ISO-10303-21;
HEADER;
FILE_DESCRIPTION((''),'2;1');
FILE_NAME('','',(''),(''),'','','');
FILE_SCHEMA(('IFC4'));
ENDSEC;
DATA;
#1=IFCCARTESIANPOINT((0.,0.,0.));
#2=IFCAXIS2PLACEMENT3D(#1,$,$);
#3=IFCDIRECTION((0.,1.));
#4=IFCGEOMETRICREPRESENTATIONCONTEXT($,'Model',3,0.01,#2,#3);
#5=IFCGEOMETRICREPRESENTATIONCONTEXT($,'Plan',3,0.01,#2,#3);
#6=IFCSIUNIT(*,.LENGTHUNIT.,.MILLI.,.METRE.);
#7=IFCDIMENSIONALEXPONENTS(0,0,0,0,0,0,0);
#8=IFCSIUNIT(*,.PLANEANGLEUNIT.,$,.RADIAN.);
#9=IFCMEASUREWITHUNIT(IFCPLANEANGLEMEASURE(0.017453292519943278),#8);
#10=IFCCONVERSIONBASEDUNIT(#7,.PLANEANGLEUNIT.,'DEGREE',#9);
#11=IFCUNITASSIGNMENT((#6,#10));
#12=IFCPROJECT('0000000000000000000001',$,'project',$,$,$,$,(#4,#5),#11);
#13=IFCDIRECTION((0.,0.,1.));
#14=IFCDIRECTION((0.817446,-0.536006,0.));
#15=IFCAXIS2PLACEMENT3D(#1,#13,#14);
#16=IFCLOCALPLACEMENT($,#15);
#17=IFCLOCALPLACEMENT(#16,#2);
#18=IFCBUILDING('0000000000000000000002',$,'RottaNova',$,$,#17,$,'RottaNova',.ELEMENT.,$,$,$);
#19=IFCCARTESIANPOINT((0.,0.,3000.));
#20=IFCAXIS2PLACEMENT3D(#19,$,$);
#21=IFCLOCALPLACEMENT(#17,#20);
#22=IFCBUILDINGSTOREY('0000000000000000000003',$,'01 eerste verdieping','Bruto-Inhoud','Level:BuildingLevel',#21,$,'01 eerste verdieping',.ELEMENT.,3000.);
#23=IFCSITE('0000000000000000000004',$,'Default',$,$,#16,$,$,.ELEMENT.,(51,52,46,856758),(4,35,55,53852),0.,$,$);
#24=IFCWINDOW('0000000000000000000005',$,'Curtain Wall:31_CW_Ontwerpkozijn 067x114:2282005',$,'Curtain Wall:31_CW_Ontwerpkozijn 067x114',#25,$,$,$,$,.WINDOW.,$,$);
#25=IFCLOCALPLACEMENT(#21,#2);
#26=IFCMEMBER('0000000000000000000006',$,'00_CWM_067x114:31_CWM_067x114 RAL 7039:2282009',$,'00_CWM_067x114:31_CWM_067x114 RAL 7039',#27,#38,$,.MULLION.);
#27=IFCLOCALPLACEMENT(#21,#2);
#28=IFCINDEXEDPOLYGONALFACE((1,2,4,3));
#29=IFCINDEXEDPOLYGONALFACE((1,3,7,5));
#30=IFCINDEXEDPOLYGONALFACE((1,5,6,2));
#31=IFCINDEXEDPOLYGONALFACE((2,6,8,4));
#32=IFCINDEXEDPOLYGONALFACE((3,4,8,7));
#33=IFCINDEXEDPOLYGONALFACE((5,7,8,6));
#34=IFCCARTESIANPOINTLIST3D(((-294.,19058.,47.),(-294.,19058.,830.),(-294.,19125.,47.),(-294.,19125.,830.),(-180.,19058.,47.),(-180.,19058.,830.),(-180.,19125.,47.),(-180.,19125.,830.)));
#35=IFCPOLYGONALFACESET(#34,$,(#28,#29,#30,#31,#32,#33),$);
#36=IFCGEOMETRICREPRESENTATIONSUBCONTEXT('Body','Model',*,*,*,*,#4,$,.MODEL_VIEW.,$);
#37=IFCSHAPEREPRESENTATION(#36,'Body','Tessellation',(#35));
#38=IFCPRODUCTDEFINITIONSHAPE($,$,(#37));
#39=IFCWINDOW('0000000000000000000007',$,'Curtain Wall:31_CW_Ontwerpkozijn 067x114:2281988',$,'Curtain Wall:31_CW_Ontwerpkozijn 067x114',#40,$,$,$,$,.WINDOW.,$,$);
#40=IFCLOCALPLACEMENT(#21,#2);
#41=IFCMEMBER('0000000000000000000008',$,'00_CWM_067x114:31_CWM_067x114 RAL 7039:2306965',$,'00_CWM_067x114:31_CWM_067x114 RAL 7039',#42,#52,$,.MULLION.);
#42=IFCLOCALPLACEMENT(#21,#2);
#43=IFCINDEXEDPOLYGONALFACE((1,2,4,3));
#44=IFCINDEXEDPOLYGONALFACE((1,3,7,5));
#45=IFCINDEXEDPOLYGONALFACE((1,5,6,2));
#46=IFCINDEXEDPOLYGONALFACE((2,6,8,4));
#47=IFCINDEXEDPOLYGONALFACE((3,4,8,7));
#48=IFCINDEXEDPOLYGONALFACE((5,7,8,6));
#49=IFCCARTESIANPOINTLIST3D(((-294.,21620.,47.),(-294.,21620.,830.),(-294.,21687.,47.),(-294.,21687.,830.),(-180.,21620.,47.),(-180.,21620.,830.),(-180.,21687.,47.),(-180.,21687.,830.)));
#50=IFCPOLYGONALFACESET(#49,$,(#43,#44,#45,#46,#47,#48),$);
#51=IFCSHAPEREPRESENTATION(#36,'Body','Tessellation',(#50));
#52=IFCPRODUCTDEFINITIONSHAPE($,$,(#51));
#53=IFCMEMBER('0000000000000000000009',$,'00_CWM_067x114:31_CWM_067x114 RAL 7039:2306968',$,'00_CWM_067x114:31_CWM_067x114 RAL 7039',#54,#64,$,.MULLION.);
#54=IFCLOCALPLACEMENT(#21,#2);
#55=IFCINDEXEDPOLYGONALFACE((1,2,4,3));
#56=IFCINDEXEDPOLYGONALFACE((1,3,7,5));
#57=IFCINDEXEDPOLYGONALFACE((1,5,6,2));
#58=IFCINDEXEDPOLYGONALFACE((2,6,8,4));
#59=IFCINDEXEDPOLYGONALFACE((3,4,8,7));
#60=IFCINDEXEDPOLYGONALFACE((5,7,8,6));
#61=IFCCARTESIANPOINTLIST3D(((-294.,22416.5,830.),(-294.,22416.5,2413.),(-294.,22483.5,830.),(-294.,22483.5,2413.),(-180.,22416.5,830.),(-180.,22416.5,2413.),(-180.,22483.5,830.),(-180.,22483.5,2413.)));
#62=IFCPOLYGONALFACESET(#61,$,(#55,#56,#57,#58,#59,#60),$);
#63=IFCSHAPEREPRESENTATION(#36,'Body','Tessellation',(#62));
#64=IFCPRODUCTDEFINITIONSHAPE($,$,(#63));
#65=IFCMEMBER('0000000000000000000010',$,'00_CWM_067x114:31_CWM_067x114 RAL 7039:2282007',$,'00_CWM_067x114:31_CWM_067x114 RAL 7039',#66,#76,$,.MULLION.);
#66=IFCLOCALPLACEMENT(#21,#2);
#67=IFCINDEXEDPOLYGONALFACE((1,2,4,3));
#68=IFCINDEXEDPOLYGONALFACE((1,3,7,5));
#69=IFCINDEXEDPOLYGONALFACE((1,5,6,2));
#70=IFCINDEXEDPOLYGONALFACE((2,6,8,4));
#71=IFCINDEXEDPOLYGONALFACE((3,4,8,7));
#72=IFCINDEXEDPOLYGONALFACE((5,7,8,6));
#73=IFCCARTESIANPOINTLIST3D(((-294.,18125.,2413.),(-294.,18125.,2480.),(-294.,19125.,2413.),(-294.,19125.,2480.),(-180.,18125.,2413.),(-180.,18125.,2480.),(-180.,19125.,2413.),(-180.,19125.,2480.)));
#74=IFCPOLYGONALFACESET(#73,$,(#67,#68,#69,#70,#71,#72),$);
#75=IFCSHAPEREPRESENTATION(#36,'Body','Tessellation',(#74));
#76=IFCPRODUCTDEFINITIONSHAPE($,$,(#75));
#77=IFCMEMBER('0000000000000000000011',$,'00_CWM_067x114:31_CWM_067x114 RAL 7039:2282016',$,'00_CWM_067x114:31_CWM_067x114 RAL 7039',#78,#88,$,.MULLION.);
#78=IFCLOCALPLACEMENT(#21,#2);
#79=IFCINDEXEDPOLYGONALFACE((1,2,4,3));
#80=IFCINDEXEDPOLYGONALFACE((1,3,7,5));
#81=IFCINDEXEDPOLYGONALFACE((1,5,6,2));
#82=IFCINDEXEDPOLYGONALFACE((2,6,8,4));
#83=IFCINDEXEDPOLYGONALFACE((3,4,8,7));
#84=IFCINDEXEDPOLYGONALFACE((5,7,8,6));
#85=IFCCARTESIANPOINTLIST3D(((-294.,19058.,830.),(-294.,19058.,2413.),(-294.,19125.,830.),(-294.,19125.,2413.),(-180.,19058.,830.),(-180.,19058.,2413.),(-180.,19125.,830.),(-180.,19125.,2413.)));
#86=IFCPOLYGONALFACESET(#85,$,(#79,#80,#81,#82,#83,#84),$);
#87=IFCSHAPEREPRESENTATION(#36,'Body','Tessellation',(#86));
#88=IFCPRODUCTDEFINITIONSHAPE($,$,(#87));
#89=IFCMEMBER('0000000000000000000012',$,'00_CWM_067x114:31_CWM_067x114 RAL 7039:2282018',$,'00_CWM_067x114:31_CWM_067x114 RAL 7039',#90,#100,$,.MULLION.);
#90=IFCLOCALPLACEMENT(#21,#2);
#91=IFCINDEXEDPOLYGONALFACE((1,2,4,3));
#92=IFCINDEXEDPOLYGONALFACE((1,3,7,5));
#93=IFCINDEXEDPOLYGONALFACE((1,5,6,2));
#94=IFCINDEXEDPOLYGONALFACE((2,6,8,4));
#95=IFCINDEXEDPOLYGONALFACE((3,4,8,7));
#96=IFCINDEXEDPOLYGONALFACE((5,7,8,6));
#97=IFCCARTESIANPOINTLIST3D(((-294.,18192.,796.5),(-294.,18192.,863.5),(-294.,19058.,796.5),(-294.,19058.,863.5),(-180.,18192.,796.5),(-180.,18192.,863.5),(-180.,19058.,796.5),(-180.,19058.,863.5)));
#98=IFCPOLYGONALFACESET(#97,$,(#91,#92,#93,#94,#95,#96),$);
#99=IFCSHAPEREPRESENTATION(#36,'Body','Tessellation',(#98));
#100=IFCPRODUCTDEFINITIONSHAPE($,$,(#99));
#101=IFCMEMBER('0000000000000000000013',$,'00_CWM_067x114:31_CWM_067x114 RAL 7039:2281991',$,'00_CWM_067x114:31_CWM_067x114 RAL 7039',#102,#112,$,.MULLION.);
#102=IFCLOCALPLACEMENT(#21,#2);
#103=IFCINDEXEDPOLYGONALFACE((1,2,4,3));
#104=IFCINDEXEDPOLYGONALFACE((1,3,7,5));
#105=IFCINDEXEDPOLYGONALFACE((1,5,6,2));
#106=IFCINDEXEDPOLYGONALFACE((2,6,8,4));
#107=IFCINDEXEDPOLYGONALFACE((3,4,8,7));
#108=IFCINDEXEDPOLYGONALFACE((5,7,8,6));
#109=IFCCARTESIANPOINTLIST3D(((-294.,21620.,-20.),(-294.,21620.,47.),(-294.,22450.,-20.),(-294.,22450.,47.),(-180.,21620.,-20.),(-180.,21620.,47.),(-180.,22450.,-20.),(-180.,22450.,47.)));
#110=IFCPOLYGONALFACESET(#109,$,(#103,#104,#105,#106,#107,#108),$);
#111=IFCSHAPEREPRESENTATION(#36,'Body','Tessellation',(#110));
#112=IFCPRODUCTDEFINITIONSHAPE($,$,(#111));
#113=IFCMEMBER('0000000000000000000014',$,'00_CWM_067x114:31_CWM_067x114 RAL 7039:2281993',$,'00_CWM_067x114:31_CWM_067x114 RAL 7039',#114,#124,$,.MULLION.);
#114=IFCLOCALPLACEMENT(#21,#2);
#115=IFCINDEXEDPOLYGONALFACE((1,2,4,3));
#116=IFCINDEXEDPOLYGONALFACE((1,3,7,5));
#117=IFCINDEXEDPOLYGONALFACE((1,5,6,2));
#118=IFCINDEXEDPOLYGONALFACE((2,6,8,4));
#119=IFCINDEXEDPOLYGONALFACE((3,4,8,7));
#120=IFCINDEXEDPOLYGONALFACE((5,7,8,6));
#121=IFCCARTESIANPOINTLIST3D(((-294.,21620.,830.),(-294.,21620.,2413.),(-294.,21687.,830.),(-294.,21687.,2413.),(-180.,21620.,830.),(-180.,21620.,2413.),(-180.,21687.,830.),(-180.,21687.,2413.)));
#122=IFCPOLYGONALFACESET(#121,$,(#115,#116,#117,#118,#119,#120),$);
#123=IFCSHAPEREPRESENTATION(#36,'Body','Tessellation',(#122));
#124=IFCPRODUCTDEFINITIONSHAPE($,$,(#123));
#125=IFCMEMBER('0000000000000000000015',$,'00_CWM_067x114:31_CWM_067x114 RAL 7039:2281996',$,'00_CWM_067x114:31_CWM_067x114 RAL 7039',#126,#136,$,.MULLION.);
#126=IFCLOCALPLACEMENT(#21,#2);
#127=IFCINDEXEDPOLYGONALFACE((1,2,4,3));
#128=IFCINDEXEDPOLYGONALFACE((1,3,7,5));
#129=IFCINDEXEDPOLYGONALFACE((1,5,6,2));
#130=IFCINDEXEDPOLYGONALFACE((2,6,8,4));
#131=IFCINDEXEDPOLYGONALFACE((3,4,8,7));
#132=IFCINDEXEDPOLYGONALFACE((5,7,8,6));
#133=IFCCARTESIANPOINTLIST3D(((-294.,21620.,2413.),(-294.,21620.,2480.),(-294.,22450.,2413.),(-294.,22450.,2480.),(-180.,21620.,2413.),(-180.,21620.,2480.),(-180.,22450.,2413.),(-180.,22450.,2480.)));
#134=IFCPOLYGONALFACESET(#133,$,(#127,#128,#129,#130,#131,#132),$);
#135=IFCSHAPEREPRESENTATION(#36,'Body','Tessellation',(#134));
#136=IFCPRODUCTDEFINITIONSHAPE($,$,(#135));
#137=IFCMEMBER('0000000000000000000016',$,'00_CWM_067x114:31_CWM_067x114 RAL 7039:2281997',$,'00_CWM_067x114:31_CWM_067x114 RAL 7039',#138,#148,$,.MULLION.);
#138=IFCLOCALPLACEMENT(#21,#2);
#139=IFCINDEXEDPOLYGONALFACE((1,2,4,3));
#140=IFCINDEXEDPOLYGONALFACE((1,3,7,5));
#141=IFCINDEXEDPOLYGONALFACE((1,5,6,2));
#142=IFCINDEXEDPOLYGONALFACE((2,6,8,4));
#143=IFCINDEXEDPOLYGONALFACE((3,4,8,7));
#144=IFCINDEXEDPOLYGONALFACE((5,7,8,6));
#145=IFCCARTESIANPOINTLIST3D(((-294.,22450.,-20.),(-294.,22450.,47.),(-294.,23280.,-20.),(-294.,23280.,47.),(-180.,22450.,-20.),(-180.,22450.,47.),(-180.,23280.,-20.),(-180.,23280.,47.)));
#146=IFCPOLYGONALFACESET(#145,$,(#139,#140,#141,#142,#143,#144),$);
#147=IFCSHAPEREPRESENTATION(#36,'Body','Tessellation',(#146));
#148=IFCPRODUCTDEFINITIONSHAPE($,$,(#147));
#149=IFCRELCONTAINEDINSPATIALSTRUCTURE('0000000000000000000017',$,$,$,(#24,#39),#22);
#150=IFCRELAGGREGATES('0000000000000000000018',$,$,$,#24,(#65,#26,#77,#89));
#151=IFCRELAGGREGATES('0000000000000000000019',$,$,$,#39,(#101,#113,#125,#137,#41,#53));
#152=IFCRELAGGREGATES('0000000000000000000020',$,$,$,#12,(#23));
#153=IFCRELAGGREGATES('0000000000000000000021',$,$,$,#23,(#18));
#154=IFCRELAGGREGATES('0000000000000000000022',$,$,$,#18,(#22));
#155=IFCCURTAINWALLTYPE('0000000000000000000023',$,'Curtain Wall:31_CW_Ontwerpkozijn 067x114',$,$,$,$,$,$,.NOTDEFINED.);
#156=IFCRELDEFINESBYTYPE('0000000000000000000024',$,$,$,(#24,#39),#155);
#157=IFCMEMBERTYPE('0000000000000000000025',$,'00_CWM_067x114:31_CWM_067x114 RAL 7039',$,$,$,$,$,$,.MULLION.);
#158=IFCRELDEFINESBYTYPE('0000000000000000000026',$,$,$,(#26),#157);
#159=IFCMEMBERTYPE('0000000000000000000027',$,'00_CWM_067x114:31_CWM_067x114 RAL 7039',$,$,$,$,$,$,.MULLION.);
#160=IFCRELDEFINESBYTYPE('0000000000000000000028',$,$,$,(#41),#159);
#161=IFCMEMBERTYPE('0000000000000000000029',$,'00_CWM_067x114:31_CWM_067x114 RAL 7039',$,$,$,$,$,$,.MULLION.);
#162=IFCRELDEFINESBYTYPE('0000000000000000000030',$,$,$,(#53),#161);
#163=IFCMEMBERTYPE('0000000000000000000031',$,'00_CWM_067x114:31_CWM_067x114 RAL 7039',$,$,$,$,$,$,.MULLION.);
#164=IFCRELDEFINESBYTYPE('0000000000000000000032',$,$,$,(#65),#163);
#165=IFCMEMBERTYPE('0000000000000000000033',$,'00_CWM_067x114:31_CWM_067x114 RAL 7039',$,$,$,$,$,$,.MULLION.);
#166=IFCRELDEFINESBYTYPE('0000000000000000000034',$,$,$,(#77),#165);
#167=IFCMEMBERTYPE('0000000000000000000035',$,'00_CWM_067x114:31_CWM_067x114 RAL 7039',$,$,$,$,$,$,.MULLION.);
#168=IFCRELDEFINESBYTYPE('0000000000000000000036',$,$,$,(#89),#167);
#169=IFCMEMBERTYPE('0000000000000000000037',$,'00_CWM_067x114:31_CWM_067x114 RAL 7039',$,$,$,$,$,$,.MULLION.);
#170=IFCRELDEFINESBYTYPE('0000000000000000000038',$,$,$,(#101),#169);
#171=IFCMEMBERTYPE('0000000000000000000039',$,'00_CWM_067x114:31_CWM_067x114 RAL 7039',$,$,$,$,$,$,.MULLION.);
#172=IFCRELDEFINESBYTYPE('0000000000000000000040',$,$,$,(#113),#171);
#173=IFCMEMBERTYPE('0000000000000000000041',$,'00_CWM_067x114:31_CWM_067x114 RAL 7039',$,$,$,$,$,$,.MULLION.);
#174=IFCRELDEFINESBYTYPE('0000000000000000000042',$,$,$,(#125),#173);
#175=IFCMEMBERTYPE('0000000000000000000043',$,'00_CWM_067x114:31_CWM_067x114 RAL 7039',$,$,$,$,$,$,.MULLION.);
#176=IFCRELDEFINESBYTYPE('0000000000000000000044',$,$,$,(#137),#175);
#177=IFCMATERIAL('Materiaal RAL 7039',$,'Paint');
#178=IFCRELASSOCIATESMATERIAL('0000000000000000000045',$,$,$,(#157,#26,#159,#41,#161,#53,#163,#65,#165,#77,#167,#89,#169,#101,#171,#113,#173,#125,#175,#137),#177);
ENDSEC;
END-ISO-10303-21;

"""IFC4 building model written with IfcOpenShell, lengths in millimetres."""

from ifc_helpers import new_model, entity, si_unit, converted_unit, direction, frame, origin, place, context, subcontext, project, spatial, indexed_curve, outline, extrude, source, transform, mapped, material, type_object, type_shapes, element, aggregate, save


model = new_model("IFC4")

# Units and contexts
model_context = context("Model", 3, precision=0.01, world=origin(), true_north=direction((0.0, 1.0)))
plan_context = context("Plan", 3, precision=0.01, world=origin(), true_north=direction((0.0, 1.0)))
body_context = subcontext(model_context, "Body", "Model", "MODEL_VIEW")
ifc_project = project(units=[si_unit("LENGTHUNIT", "METRE", prefix="MILLI"), converted_unit("PLANEANGLEUNIT", "DEGREE", entity("IfcPlaneAngleMeasure", 0.017453292519943278), si_unit("PLANEANGLEUNIT", "RADIAN"), dimensions=[0, 0, 0, 0, 0, 0, 0])], contexts=[model_context, plan_context])

# Site, building, storey
site_placement = place(None, frame((0.0, 0.0, 0.0), z_axis=(0.0, 0.0, 1.0), x_axis=(0.817446, -0.536006, 0.0)))
site = spatial("IfcSite", under=ifc_project, at=site_placement, Name="Default", CompositionType="ELEMENT", RefLatitude=(51, 52, 46, 856758), RefLongitude=(4, 35, 55, 53852), RefElevation=0.0)
building_placement = place(site_placement, origin())
building = spatial("IfcBuilding", under=site, at=building_placement, Name="RottaNova", LongName="RottaNova", CompositionType="ELEMENT")
storey_placement = place(building_placement, frame((0.0, 0.0, 3000.0)))
storey = spatial("IfcBuildingStorey", under=building, at=storey_placement, Name="01 eerste verdieping", Description="Bruto-Inhoud", ObjectType="Level:BuildingLevel", LongName="01 eerste verdieping", CompositionType="ELEMENT", Elevation=3000.0)

# Window, member
curtain_wall_type = type_object("IfcCurtainWallType", Name="Curtain Wall:31_CW_Ontwerpkozijn 067x114", PredefinedType="NOTDEFINED")
window_1_placement = place(storey_placement, frame((0.0, 0.0, -3000.0)))
window_1 = element("IfcWindow", 1, at=window_1_placement, inside=storey, type_object=curtain_wall_type, Name="Curtain Wall:31_CW_Ontwerpkozijn 067x114:2282005", ObjectType="Curtain Wall:31_CW_Ontwerpkozijn 067x114", PredefinedType="WINDOW")
ifc_material_1 = material(Name="Materiaal RAL 7039", Category="Paint")
member_type_1 = type_object("IfcMemberType", Name="00_CWM_067x114:31_CWM_067x114 RAL 7039", PredefinedType="MULLION", material=ifc_material_1)
shared_shape_1 = source(origin(), body_context, "Body", "SweptSolid", [
    extrude(outline(indexed_curve([(-33.5, -57.0), (33.5, -57.0), (33.5, 57.0), (-33.5, 57.0), (-33.5, -57.0)], self_intersect=False)), frame((-33.5, -57.0, -783.0), z_axis=(0.0, 0.0, 1.0), x_axis=(-1.0, 0.0, 0.0)), (0.0, 0.0, 1.0), 783.0),
])
type_shapes(member_type_1, [shared_shape_1])
member_1_placement = place(window_1_placement, frame((-180.0, 19125.0, 3047.0), z_axis=(0.0, 0.0, -1.0), x_axis=(0.0, 1.0, 0.0)))
member_1 = element("IfcMember", 2, at=member_1_placement, type_object=member_type_1, material=ifc_material_1, Name="00_CWM_067x114:31_CWM_067x114 RAL 7039:2282009", ObjectType="00_CWM_067x114:31_CWM_067x114 RAL 7039", PredefinedType="MULLION", context=body_context, shape_type="MappedRepresentation", body=[
    mapped(shared_shape_1, transform((0.0, 0.0, 0.0), scale=1.0)),
])

# Window, members
window_2_placement = place(storey_placement, frame((0.0, 0.0, -3000.0)))
window_2 = element("IfcWindow", 3, at=window_2_placement, inside=storey, type_object=curtain_wall_type, Name="Curtain Wall:31_CW_Ontwerpkozijn 067x114:2281988", ObjectType="Curtain Wall:31_CW_Ontwerpkozijn 067x114", PredefinedType="WINDOW")
member_type_2 = type_object("IfcMemberType", Name="00_CWM_067x114:31_CWM_067x114 RAL 7039", PredefinedType="MULLION", material=ifc_material_1)
shared_shape_2 = source(origin(), body_context, "Body", "SweptSolid", [
    extrude(outline(indexed_curve([(-33.5, -57.0), (33.5, -57.0), (33.5, 57.0), (-33.5, 57.0), (-33.5, -57.0)], self_intersect=False)), frame((-33.5, -57.0, -783.0), z_axis=(0.0, 0.0, 1.0), x_axis=(-1.0, 0.0, 0.0)), (0.0, 0.0, 1.0), 783.0),
])
type_shapes(member_type_2, [shared_shape_2])
member_2_placement = place(window_2_placement, frame((-180.0, 21620.0, 3830.0), z_axis=(0.0, 0.0, 1.0), x_axis=(0.0, -1.0, 0.0)))
member_2 = element("IfcMember", 4, at=member_2_placement, type_object=member_type_2, material=ifc_material_1, Name="00_CWM_067x114:31_CWM_067x114 RAL 7039:2306965", ObjectType="00_CWM_067x114:31_CWM_067x114 RAL 7039", PredefinedType="MULLION", context=body_context, shape_type="MappedRepresentation", body=[
    mapped(shared_shape_2, transform((0.0, 0.0, 0.0), scale=1.0)),
])
member_type_3 = type_object("IfcMemberType", Name="00_CWM_067x114:31_CWM_067x114 RAL 7039", PredefinedType="MULLION", material=ifc_material_1)
shared_shape_3 = source(origin(), body_context, "Body", "SweptSolid", [
    extrude(outline(indexed_curve([(-33.5, -57.0), (33.5, -57.0), (33.5, 57.0), (-33.5, 57.0), (-33.5, -57.0)], self_intersect=False)), frame((0.0, -57.0, -1583.0), z_axis=(0.0, 0.0, 1.0), x_axis=(-1.0, 0.0, 0.0)), (0.0, 0.0, 1.0), 1583.0),
])
type_shapes(member_type_3, [shared_shape_3])
member_3_placement = place(window_2_placement, frame((-180.0, 22450.0, 3830.0), z_axis=(0.0, 0.0, -1.0), x_axis=(0.0, 1.0, 0.0)))
member_3 = element("IfcMember", 5, at=member_3_placement, type_object=member_type_3, material=ifc_material_1, Name="00_CWM_067x114:31_CWM_067x114 RAL 7039:2306968", ObjectType="00_CWM_067x114:31_CWM_067x114 RAL 7039", PredefinedType="MULLION", context=body_context, shape_type="MappedRepresentation", body=[
    mapped(shared_shape_3, transform((0.0, 0.0, 0.0), scale=1.0)),
])

# Members
member_type_4 = type_object("IfcMemberType", Name="00_CWM_067x114:31_CWM_067x114 RAL 7039", PredefinedType="MULLION", material=ifc_material_1)
shared_shape_4 = source(origin(), body_context, "Body", "SweptSolid", [
    extrude(outline(indexed_curve([(-33.5, -57.0), (33.5, -57.0), (33.5, 57.0), (-33.5, 57.0), (-33.5, -57.0)], self_intersect=False)), frame((-33.5, -57.0, -1000.0), z_axis=(0.0, 0.0, 1.0), x_axis=(-1.0, 0.0, 0.0)), (0.0, 0.0, 1.0), 1000.0),
])
type_shapes(member_type_4, [shared_shape_4])
member_4_placement = place(window_1_placement, frame((-180.0, 19125.0, 5480.0), z_axis=(0.0, 1.0, 0.0), x_axis=(0.0, 0.0, 1.0)))
member_4 = element("IfcMember", 6, at=member_4_placement, type_object=member_type_4, material=ifc_material_1, Name="00_CWM_067x114:31_CWM_067x114 RAL 7039:2282007", ObjectType="00_CWM_067x114:31_CWM_067x114 RAL 7039", PredefinedType="MULLION", context=body_context, shape_type="MappedRepresentation", body=[
    mapped(shared_shape_4, transform((0.0, 0.0, 0.0), scale=1.0)),
])
member_type_5 = type_object("IfcMemberType", Name="00_CWM_067x114:31_CWM_067x114 RAL 7039", PredefinedType="MULLION", material=ifc_material_1)
shared_shape_5 = source(origin(), body_context, "Body", "SweptSolid", [
    extrude(outline(indexed_curve([(-33.5, -57.0), (33.5, -57.0), (33.5, 57.0), (-33.5, 57.0), (-33.5, -57.0)], self_intersect=False)), frame((-33.5, -57.0, -1583.0), z_axis=(0.0, 0.0, 1.0), x_axis=(-1.0, 0.0, 0.0)), (0.0, 0.0, 1.0), 1583.0),
])
type_shapes(member_type_5, [shared_shape_5])
member_5_placement = place(window_1_placement, frame((-180.0, 19125.0, 3830.0), z_axis=(0.0, 0.0, -1.0), x_axis=(0.0, 1.0, 0.0)))
member_5 = element("IfcMember", 7, at=member_5_placement, type_object=member_type_5, material=ifc_material_1, Name="00_CWM_067x114:31_CWM_067x114 RAL 7039:2282016", ObjectType="00_CWM_067x114:31_CWM_067x114 RAL 7039", PredefinedType="MULLION", context=body_context, shape_type="MappedRepresentation", body=[
    mapped(shared_shape_5, transform((0.0, 0.0, 0.0), scale=1.0)),
])
member_type_6 = type_object("IfcMemberType", Name="00_CWM_067x114:31_CWM_067x114 RAL 7039", PredefinedType="MULLION", material=ifc_material_1)
shared_shape_6 = source(origin(), body_context, "Body", "SweptSolid", [
    extrude(outline(indexed_curve([(-33.5, -57.0), (33.5, -57.0), (33.5, 57.0), (-33.5, 57.0), (-33.5, -57.0)], self_intersect=False)), frame((0.0, -57.0, -866.0), z_axis=(0.0, 0.0, 1.0), x_axis=(-1.0, 0.0, 0.0)), (0.0, 0.0, 1.0), 866.0),
])
type_shapes(member_type_6, [shared_shape_6])
member_6_placement = place(window_1_placement, frame((-180.0, 19058.0, 3830.0), z_axis=(0.0, 1.0, 0.0), x_axis=(0.0, 0.0, 1.0)))
member_6 = element("IfcMember", 8, at=member_6_placement, type_object=member_type_6, material=ifc_material_1, Name="00_CWM_067x114:31_CWM_067x114 RAL 7039:2282018", ObjectType="00_CWM_067x114:31_CWM_067x114 RAL 7039", PredefinedType="MULLION", context=body_context, shape_type="MappedRepresentation", body=[
    mapped(shared_shape_6, transform((0.0, 0.0, 0.0), scale=1.0)),
])
aggregate(window_1, [member_4, member_1, member_5, member_6])
member_type_7 = type_object("IfcMemberType", Name="00_CWM_067x114:31_CWM_067x114 RAL 7039", PredefinedType="MULLION", material=ifc_material_1)
shared_shape_7 = source(origin(), body_context, "Body", "SweptSolid", [
    extrude(outline(indexed_curve([(-33.5, -57.0), (33.5, -57.0), (33.5, 57.0), (-33.5, 57.0), (-33.5, -57.0)], self_intersect=False)), frame((-33.5, -57.0, -830.0), z_axis=(0.0, 0.0, 1.0), x_axis=(-1.0, 0.0, 0.0)), (0.0, 0.0, 1.0), 830.0),
])
type_shapes(member_type_7, [shared_shape_7])
member_7_placement = place(window_2_placement, frame((-180.0, 21620.0, 2980.0), z_axis=(0.0, -1.0, 0.0), x_axis=(0.0, 0.0, -1.0)))
member_7 = element("IfcMember", 9, at=member_7_placement, type_object=member_type_7, material=ifc_material_1, Name="00_CWM_067x114:31_CWM_067x114 RAL 7039:2281991", ObjectType="00_CWM_067x114:31_CWM_067x114 RAL 7039", PredefinedType="MULLION", context=body_context, shape_type="MappedRepresentation", body=[
    mapped(shared_shape_7, transform((0.0, 0.0, 0.0), scale=1.0)),
])
member_type_8 = type_object("IfcMemberType", Name="00_CWM_067x114:31_CWM_067x114 RAL 7039", PredefinedType="MULLION", material=ifc_material_1)
shared_shape_8 = source(origin(), body_context, "Body", "SweptSolid", [
    extrude(outline(indexed_curve([(-33.5, -57.0), (33.5, -57.0), (33.5, 57.0), (-33.5, 57.0), (-33.5, -57.0)], self_intersect=False)), frame((-33.5, -57.0, -1583.0), z_axis=(0.0, 0.0, 1.0), x_axis=(-1.0, 0.0, 0.0)), (0.0, 0.0, 1.0), 1583.0),
])
type_shapes(member_type_8, [shared_shape_8])
member_8_placement = place(window_2_placement, frame((-180.0, 21620.0, 5413.0), z_axis=(0.0, 0.0, 1.0), x_axis=(0.0, -1.0, 0.0)))
member_8 = element("IfcMember", 10, at=member_8_placement, type_object=member_type_8, material=ifc_material_1, Name="00_CWM_067x114:31_CWM_067x114 RAL 7039:2281993", ObjectType="00_CWM_067x114:31_CWM_067x114 RAL 7039", PredefinedType="MULLION", context=body_context, shape_type="MappedRepresentation", body=[
    mapped(shared_shape_8, transform((0.0, 0.0, 0.0), scale=1.0)),
])
member_type_9 = type_object("IfcMemberType", Name="00_CWM_067x114:31_CWM_067x114 RAL 7039", PredefinedType="MULLION", material=ifc_material_1)
shared_shape_9 = source(origin(), body_context, "Body", "SweptSolid", [
    extrude(outline(indexed_curve([(-33.5, -57.0), (33.5, -57.0), (33.5, 57.0), (-33.5, 57.0), (-33.5, -57.0)], self_intersect=False)), frame((-33.5, -57.0, -830.0), z_axis=(0.0, 0.0, 1.0), x_axis=(-1.0, 0.0, 0.0)), (0.0, 0.0, 1.0), 830.0),
])
type_shapes(member_type_9, [shared_shape_9])
member_9_placement = place(window_2_placement, frame((-180.0, 22450.0, 5480.0), z_axis=(0.0, 1.0, 0.0), x_axis=(0.0, 0.0, 1.0)))
member_9 = element("IfcMember", 11, at=member_9_placement, type_object=member_type_9, material=ifc_material_1, Name="00_CWM_067x114:31_CWM_067x114 RAL 7039:2281996", ObjectType="00_CWM_067x114:31_CWM_067x114 RAL 7039", PredefinedType="MULLION", context=body_context, shape_type="MappedRepresentation", body=[
    mapped(shared_shape_9, transform((0.0, 0.0, 0.0), scale=1.0)),
])
member_type_10 = type_object("IfcMemberType", Name="00_CWM_067x114:31_CWM_067x114 RAL 7039", PredefinedType="MULLION", material=ifc_material_1)
shared_shape_10 = source(origin(), body_context, "Body", "SweptSolid", [
    extrude(outline(indexed_curve([(-33.5, -57.0), (33.5, -57.0), (33.5, 57.0), (-33.5, 57.0), (-33.5, -57.0)], self_intersect=False)), frame((-33.5, -57.0, -830.0), z_axis=(0.0, 0.0, 1.0), x_axis=(-1.0, 0.0, 0.0)), (0.0, 0.0, 1.0), 830.0),
])
type_shapes(member_type_10, [shared_shape_10])
member_10_placement = place(window_2_placement, frame((-180.0, 22450.0, 2980.0), z_axis=(0.0, -1.0, 0.0), x_axis=(0.0, 0.0, -1.0)))
member_10 = element("IfcMember", 12, at=member_10_placement, type_object=member_type_10, material=ifc_material_1, Name="00_CWM_067x114:31_CWM_067x114 RAL 7039:2281997", ObjectType="00_CWM_067x114:31_CWM_067x114 RAL 7039", PredefinedType="MULLION", context=body_context, shape_type="MappedRepresentation", body=[
    mapped(shared_shape_10, transform((0.0, 0.0, 0.0), scale=1.0)),
])

aggregate(window_2, [member_7, member_8, member_9, member_10, member_2, member_3])

save(model, "model.ifc")
